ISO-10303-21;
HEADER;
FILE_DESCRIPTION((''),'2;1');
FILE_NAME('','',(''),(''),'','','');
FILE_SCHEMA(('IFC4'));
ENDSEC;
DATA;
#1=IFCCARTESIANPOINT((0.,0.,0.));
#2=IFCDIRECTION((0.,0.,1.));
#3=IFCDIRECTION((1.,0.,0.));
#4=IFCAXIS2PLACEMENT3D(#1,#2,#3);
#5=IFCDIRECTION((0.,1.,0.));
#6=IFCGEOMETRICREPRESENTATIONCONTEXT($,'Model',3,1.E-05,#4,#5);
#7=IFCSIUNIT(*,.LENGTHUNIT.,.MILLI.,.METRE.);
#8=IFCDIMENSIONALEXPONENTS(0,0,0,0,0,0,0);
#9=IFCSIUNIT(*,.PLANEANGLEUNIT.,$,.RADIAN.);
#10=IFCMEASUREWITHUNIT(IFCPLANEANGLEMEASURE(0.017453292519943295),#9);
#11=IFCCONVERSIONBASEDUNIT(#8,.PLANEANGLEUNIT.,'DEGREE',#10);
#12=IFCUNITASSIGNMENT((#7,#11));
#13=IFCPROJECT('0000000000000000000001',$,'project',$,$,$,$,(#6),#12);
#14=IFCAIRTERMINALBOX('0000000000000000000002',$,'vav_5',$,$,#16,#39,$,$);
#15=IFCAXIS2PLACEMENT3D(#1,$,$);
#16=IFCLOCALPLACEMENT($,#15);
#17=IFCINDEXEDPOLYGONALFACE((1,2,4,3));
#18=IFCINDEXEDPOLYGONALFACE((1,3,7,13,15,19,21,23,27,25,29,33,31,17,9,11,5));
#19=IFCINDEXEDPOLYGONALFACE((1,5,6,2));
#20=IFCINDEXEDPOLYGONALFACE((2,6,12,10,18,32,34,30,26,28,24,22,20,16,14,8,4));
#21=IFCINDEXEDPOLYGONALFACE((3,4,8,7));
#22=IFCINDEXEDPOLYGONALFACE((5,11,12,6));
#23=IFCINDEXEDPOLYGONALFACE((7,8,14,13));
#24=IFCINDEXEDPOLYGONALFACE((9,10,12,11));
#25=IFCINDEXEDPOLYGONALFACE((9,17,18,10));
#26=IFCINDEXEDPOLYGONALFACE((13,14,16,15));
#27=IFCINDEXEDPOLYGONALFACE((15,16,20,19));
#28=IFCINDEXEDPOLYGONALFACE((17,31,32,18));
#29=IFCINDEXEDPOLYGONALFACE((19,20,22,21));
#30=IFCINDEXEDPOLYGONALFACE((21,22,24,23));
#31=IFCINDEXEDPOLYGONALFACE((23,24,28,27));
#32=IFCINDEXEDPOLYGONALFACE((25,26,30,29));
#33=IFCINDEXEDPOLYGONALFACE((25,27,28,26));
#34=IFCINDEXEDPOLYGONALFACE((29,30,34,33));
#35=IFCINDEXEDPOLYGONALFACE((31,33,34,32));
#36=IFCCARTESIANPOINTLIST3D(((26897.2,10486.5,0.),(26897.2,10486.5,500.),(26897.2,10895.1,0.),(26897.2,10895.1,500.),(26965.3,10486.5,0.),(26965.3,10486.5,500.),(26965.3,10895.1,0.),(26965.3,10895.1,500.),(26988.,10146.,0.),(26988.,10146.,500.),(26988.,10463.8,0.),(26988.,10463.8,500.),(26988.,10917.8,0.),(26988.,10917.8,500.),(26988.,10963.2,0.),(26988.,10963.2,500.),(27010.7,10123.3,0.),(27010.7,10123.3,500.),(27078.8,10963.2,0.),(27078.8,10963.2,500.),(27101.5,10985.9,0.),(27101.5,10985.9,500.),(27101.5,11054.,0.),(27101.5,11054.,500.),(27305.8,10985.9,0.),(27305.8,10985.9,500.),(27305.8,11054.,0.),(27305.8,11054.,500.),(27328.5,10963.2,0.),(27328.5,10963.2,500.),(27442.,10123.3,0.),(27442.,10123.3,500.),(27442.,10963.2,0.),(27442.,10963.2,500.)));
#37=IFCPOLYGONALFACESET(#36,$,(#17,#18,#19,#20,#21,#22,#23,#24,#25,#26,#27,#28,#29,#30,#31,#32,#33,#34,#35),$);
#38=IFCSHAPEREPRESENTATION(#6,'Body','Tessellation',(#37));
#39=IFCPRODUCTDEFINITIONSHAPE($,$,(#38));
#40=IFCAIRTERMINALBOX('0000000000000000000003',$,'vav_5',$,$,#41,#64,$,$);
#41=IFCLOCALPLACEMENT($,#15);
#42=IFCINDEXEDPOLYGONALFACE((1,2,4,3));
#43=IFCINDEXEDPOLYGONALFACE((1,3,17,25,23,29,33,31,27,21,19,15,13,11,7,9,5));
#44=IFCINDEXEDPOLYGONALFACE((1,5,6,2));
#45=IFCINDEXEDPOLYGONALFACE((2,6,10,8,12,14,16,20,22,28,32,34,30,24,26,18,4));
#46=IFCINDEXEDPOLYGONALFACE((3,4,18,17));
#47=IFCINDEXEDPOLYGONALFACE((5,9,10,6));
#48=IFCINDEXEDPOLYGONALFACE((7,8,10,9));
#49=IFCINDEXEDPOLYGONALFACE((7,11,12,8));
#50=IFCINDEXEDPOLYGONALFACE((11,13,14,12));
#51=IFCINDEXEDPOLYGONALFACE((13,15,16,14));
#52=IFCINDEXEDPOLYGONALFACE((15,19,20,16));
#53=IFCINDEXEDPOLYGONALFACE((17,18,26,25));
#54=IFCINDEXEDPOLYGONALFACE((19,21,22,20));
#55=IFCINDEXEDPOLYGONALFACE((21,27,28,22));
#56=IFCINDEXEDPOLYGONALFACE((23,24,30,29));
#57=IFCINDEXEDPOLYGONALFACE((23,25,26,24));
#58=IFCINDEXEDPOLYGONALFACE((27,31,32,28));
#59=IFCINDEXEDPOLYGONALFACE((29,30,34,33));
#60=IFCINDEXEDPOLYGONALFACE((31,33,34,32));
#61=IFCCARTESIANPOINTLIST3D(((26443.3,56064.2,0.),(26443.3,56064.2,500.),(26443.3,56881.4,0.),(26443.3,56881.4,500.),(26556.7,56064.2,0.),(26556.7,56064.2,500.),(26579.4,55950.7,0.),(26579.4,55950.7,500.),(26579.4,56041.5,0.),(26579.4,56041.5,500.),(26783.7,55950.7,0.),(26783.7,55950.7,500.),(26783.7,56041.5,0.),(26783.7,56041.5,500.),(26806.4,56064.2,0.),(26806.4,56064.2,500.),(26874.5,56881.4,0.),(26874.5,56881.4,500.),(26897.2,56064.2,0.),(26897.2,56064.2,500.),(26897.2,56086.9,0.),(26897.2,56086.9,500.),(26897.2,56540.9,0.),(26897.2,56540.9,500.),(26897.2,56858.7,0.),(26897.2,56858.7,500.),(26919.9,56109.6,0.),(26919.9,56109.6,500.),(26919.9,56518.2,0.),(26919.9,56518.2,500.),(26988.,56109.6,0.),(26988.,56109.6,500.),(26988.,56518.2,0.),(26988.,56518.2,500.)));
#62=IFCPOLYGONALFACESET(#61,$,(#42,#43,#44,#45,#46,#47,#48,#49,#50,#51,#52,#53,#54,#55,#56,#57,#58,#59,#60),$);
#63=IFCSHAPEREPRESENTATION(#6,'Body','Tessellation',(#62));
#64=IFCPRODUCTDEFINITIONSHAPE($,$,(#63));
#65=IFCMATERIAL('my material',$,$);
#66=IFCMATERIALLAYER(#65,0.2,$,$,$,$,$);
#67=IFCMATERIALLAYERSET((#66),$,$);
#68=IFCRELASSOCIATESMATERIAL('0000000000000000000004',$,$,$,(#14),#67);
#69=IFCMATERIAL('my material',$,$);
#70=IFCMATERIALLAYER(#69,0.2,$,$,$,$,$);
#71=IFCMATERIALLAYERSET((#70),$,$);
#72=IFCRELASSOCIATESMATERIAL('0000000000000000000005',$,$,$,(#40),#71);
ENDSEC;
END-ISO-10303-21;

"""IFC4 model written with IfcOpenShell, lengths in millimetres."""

from ifc_helpers import new_model, entity, si_unit, converted_unit, direction, origin_with_axes, place, context, project, polyline, outline, extrude, material, layer, layer_set, layer_usage, element, save


model = new_model("IFC4")

# Units and contexts
model_context = context("Model", 3, precision=1e-05, world=origin_with_axes(), true_north=direction((0.0, 1.0, 0.0)))
ifc_project = project(units=[si_unit("LENGTHUNIT", "METRE", prefix="MILLI"), converted_unit("PLANEANGLEUNIT", "DEGREE", entity("IfcPlaneAngleMeasure", 0.017453292519943295), si_unit("PLANEANGLEUNIT", "RADIAN"), dimensions=[0, 0, 0, 0, 0, 0, 0])], contexts=[model_context])

# Air terminal boxes
ifc_material_1 = material(Name="my material")
ifc_layer_1 = layer(ifc_material_1, 0.2)
ifc_layer_set_1 = layer_set([ifc_layer_1])
ifc_layer_usage_1 = layer_usage(ifc_layer_set_1, "AXIS2", "POSITIVE", -0.1)
air_terminal_box_1_placement = place(None, origin_with_axes())
element("IfcAirTerminalBox", 1, at=air_terminal_box_1_placement, material=ifc_layer_usage_1, Name="vav_5", context=model_context, shape_type="SweptSolid", body=[
    extrude(outline(polyline([(26897.2, 10486.5), (26965.3, 10486.5), (26988.0, 10463.8), (26988.0, 10146.0), (27010.7, 10123.3), (27442.0, 10123.3), (27442.0, 10963.2), (27328.5, 10963.2), (27305.8, 10985.9), (27305.8, 11054.0), (27101.5, 11054.0), (27101.5, 10985.9), (27078.8, 10963.2), (26988.0, 10963.2), (26988.0, 10917.8), (26965.3, 10895.1), (26897.2, 10895.1), (26897.2, 10486.5)])), origin_with_axes(), (0.0, 0.0, 1.0), 500.0),
])
ifc_material_2 = material(Name="my material")
ifc_layer_2 = layer(ifc_material_2, 0.2)
ifc_layer_set_2 = layer_set([ifc_layer_2])
ifc_layer_usage_2 = layer_usage(ifc_layer_set_2, "AXIS2", "POSITIVE", -0.1)
air_terminal_box_2_placement = place(None, origin_with_axes())
element("IfcAirTerminalBox", 2, at=air_terminal_box_2_placement, material=ifc_layer_usage_2, Name="vav_5", context=model_context, shape_type="SweptSolid", body=[
    extrude(outline(polyline([(26443.3, 56064.2), (26556.7, 56064.2), (26579.4, 56041.5), (26579.4, 55950.7), (26783.7, 55950.7), (26783.7, 56041.5), (26806.4, 56064.2), (26897.2, 56064.2), (26897.2, 56086.9), (26919.9, 56109.6), (26988.0, 56109.6), (26988.0, 56518.2), (26919.9, 56518.2), (26897.2, 56540.9), (26897.2, 56858.7), (26874.5, 56881.4), (26443.3, 56881.4), (26443.3, 56064.2)])), origin_with_axes(), (0.0, 0.0, 1.0), 500.0),
])

save(model, "model.ifc")
